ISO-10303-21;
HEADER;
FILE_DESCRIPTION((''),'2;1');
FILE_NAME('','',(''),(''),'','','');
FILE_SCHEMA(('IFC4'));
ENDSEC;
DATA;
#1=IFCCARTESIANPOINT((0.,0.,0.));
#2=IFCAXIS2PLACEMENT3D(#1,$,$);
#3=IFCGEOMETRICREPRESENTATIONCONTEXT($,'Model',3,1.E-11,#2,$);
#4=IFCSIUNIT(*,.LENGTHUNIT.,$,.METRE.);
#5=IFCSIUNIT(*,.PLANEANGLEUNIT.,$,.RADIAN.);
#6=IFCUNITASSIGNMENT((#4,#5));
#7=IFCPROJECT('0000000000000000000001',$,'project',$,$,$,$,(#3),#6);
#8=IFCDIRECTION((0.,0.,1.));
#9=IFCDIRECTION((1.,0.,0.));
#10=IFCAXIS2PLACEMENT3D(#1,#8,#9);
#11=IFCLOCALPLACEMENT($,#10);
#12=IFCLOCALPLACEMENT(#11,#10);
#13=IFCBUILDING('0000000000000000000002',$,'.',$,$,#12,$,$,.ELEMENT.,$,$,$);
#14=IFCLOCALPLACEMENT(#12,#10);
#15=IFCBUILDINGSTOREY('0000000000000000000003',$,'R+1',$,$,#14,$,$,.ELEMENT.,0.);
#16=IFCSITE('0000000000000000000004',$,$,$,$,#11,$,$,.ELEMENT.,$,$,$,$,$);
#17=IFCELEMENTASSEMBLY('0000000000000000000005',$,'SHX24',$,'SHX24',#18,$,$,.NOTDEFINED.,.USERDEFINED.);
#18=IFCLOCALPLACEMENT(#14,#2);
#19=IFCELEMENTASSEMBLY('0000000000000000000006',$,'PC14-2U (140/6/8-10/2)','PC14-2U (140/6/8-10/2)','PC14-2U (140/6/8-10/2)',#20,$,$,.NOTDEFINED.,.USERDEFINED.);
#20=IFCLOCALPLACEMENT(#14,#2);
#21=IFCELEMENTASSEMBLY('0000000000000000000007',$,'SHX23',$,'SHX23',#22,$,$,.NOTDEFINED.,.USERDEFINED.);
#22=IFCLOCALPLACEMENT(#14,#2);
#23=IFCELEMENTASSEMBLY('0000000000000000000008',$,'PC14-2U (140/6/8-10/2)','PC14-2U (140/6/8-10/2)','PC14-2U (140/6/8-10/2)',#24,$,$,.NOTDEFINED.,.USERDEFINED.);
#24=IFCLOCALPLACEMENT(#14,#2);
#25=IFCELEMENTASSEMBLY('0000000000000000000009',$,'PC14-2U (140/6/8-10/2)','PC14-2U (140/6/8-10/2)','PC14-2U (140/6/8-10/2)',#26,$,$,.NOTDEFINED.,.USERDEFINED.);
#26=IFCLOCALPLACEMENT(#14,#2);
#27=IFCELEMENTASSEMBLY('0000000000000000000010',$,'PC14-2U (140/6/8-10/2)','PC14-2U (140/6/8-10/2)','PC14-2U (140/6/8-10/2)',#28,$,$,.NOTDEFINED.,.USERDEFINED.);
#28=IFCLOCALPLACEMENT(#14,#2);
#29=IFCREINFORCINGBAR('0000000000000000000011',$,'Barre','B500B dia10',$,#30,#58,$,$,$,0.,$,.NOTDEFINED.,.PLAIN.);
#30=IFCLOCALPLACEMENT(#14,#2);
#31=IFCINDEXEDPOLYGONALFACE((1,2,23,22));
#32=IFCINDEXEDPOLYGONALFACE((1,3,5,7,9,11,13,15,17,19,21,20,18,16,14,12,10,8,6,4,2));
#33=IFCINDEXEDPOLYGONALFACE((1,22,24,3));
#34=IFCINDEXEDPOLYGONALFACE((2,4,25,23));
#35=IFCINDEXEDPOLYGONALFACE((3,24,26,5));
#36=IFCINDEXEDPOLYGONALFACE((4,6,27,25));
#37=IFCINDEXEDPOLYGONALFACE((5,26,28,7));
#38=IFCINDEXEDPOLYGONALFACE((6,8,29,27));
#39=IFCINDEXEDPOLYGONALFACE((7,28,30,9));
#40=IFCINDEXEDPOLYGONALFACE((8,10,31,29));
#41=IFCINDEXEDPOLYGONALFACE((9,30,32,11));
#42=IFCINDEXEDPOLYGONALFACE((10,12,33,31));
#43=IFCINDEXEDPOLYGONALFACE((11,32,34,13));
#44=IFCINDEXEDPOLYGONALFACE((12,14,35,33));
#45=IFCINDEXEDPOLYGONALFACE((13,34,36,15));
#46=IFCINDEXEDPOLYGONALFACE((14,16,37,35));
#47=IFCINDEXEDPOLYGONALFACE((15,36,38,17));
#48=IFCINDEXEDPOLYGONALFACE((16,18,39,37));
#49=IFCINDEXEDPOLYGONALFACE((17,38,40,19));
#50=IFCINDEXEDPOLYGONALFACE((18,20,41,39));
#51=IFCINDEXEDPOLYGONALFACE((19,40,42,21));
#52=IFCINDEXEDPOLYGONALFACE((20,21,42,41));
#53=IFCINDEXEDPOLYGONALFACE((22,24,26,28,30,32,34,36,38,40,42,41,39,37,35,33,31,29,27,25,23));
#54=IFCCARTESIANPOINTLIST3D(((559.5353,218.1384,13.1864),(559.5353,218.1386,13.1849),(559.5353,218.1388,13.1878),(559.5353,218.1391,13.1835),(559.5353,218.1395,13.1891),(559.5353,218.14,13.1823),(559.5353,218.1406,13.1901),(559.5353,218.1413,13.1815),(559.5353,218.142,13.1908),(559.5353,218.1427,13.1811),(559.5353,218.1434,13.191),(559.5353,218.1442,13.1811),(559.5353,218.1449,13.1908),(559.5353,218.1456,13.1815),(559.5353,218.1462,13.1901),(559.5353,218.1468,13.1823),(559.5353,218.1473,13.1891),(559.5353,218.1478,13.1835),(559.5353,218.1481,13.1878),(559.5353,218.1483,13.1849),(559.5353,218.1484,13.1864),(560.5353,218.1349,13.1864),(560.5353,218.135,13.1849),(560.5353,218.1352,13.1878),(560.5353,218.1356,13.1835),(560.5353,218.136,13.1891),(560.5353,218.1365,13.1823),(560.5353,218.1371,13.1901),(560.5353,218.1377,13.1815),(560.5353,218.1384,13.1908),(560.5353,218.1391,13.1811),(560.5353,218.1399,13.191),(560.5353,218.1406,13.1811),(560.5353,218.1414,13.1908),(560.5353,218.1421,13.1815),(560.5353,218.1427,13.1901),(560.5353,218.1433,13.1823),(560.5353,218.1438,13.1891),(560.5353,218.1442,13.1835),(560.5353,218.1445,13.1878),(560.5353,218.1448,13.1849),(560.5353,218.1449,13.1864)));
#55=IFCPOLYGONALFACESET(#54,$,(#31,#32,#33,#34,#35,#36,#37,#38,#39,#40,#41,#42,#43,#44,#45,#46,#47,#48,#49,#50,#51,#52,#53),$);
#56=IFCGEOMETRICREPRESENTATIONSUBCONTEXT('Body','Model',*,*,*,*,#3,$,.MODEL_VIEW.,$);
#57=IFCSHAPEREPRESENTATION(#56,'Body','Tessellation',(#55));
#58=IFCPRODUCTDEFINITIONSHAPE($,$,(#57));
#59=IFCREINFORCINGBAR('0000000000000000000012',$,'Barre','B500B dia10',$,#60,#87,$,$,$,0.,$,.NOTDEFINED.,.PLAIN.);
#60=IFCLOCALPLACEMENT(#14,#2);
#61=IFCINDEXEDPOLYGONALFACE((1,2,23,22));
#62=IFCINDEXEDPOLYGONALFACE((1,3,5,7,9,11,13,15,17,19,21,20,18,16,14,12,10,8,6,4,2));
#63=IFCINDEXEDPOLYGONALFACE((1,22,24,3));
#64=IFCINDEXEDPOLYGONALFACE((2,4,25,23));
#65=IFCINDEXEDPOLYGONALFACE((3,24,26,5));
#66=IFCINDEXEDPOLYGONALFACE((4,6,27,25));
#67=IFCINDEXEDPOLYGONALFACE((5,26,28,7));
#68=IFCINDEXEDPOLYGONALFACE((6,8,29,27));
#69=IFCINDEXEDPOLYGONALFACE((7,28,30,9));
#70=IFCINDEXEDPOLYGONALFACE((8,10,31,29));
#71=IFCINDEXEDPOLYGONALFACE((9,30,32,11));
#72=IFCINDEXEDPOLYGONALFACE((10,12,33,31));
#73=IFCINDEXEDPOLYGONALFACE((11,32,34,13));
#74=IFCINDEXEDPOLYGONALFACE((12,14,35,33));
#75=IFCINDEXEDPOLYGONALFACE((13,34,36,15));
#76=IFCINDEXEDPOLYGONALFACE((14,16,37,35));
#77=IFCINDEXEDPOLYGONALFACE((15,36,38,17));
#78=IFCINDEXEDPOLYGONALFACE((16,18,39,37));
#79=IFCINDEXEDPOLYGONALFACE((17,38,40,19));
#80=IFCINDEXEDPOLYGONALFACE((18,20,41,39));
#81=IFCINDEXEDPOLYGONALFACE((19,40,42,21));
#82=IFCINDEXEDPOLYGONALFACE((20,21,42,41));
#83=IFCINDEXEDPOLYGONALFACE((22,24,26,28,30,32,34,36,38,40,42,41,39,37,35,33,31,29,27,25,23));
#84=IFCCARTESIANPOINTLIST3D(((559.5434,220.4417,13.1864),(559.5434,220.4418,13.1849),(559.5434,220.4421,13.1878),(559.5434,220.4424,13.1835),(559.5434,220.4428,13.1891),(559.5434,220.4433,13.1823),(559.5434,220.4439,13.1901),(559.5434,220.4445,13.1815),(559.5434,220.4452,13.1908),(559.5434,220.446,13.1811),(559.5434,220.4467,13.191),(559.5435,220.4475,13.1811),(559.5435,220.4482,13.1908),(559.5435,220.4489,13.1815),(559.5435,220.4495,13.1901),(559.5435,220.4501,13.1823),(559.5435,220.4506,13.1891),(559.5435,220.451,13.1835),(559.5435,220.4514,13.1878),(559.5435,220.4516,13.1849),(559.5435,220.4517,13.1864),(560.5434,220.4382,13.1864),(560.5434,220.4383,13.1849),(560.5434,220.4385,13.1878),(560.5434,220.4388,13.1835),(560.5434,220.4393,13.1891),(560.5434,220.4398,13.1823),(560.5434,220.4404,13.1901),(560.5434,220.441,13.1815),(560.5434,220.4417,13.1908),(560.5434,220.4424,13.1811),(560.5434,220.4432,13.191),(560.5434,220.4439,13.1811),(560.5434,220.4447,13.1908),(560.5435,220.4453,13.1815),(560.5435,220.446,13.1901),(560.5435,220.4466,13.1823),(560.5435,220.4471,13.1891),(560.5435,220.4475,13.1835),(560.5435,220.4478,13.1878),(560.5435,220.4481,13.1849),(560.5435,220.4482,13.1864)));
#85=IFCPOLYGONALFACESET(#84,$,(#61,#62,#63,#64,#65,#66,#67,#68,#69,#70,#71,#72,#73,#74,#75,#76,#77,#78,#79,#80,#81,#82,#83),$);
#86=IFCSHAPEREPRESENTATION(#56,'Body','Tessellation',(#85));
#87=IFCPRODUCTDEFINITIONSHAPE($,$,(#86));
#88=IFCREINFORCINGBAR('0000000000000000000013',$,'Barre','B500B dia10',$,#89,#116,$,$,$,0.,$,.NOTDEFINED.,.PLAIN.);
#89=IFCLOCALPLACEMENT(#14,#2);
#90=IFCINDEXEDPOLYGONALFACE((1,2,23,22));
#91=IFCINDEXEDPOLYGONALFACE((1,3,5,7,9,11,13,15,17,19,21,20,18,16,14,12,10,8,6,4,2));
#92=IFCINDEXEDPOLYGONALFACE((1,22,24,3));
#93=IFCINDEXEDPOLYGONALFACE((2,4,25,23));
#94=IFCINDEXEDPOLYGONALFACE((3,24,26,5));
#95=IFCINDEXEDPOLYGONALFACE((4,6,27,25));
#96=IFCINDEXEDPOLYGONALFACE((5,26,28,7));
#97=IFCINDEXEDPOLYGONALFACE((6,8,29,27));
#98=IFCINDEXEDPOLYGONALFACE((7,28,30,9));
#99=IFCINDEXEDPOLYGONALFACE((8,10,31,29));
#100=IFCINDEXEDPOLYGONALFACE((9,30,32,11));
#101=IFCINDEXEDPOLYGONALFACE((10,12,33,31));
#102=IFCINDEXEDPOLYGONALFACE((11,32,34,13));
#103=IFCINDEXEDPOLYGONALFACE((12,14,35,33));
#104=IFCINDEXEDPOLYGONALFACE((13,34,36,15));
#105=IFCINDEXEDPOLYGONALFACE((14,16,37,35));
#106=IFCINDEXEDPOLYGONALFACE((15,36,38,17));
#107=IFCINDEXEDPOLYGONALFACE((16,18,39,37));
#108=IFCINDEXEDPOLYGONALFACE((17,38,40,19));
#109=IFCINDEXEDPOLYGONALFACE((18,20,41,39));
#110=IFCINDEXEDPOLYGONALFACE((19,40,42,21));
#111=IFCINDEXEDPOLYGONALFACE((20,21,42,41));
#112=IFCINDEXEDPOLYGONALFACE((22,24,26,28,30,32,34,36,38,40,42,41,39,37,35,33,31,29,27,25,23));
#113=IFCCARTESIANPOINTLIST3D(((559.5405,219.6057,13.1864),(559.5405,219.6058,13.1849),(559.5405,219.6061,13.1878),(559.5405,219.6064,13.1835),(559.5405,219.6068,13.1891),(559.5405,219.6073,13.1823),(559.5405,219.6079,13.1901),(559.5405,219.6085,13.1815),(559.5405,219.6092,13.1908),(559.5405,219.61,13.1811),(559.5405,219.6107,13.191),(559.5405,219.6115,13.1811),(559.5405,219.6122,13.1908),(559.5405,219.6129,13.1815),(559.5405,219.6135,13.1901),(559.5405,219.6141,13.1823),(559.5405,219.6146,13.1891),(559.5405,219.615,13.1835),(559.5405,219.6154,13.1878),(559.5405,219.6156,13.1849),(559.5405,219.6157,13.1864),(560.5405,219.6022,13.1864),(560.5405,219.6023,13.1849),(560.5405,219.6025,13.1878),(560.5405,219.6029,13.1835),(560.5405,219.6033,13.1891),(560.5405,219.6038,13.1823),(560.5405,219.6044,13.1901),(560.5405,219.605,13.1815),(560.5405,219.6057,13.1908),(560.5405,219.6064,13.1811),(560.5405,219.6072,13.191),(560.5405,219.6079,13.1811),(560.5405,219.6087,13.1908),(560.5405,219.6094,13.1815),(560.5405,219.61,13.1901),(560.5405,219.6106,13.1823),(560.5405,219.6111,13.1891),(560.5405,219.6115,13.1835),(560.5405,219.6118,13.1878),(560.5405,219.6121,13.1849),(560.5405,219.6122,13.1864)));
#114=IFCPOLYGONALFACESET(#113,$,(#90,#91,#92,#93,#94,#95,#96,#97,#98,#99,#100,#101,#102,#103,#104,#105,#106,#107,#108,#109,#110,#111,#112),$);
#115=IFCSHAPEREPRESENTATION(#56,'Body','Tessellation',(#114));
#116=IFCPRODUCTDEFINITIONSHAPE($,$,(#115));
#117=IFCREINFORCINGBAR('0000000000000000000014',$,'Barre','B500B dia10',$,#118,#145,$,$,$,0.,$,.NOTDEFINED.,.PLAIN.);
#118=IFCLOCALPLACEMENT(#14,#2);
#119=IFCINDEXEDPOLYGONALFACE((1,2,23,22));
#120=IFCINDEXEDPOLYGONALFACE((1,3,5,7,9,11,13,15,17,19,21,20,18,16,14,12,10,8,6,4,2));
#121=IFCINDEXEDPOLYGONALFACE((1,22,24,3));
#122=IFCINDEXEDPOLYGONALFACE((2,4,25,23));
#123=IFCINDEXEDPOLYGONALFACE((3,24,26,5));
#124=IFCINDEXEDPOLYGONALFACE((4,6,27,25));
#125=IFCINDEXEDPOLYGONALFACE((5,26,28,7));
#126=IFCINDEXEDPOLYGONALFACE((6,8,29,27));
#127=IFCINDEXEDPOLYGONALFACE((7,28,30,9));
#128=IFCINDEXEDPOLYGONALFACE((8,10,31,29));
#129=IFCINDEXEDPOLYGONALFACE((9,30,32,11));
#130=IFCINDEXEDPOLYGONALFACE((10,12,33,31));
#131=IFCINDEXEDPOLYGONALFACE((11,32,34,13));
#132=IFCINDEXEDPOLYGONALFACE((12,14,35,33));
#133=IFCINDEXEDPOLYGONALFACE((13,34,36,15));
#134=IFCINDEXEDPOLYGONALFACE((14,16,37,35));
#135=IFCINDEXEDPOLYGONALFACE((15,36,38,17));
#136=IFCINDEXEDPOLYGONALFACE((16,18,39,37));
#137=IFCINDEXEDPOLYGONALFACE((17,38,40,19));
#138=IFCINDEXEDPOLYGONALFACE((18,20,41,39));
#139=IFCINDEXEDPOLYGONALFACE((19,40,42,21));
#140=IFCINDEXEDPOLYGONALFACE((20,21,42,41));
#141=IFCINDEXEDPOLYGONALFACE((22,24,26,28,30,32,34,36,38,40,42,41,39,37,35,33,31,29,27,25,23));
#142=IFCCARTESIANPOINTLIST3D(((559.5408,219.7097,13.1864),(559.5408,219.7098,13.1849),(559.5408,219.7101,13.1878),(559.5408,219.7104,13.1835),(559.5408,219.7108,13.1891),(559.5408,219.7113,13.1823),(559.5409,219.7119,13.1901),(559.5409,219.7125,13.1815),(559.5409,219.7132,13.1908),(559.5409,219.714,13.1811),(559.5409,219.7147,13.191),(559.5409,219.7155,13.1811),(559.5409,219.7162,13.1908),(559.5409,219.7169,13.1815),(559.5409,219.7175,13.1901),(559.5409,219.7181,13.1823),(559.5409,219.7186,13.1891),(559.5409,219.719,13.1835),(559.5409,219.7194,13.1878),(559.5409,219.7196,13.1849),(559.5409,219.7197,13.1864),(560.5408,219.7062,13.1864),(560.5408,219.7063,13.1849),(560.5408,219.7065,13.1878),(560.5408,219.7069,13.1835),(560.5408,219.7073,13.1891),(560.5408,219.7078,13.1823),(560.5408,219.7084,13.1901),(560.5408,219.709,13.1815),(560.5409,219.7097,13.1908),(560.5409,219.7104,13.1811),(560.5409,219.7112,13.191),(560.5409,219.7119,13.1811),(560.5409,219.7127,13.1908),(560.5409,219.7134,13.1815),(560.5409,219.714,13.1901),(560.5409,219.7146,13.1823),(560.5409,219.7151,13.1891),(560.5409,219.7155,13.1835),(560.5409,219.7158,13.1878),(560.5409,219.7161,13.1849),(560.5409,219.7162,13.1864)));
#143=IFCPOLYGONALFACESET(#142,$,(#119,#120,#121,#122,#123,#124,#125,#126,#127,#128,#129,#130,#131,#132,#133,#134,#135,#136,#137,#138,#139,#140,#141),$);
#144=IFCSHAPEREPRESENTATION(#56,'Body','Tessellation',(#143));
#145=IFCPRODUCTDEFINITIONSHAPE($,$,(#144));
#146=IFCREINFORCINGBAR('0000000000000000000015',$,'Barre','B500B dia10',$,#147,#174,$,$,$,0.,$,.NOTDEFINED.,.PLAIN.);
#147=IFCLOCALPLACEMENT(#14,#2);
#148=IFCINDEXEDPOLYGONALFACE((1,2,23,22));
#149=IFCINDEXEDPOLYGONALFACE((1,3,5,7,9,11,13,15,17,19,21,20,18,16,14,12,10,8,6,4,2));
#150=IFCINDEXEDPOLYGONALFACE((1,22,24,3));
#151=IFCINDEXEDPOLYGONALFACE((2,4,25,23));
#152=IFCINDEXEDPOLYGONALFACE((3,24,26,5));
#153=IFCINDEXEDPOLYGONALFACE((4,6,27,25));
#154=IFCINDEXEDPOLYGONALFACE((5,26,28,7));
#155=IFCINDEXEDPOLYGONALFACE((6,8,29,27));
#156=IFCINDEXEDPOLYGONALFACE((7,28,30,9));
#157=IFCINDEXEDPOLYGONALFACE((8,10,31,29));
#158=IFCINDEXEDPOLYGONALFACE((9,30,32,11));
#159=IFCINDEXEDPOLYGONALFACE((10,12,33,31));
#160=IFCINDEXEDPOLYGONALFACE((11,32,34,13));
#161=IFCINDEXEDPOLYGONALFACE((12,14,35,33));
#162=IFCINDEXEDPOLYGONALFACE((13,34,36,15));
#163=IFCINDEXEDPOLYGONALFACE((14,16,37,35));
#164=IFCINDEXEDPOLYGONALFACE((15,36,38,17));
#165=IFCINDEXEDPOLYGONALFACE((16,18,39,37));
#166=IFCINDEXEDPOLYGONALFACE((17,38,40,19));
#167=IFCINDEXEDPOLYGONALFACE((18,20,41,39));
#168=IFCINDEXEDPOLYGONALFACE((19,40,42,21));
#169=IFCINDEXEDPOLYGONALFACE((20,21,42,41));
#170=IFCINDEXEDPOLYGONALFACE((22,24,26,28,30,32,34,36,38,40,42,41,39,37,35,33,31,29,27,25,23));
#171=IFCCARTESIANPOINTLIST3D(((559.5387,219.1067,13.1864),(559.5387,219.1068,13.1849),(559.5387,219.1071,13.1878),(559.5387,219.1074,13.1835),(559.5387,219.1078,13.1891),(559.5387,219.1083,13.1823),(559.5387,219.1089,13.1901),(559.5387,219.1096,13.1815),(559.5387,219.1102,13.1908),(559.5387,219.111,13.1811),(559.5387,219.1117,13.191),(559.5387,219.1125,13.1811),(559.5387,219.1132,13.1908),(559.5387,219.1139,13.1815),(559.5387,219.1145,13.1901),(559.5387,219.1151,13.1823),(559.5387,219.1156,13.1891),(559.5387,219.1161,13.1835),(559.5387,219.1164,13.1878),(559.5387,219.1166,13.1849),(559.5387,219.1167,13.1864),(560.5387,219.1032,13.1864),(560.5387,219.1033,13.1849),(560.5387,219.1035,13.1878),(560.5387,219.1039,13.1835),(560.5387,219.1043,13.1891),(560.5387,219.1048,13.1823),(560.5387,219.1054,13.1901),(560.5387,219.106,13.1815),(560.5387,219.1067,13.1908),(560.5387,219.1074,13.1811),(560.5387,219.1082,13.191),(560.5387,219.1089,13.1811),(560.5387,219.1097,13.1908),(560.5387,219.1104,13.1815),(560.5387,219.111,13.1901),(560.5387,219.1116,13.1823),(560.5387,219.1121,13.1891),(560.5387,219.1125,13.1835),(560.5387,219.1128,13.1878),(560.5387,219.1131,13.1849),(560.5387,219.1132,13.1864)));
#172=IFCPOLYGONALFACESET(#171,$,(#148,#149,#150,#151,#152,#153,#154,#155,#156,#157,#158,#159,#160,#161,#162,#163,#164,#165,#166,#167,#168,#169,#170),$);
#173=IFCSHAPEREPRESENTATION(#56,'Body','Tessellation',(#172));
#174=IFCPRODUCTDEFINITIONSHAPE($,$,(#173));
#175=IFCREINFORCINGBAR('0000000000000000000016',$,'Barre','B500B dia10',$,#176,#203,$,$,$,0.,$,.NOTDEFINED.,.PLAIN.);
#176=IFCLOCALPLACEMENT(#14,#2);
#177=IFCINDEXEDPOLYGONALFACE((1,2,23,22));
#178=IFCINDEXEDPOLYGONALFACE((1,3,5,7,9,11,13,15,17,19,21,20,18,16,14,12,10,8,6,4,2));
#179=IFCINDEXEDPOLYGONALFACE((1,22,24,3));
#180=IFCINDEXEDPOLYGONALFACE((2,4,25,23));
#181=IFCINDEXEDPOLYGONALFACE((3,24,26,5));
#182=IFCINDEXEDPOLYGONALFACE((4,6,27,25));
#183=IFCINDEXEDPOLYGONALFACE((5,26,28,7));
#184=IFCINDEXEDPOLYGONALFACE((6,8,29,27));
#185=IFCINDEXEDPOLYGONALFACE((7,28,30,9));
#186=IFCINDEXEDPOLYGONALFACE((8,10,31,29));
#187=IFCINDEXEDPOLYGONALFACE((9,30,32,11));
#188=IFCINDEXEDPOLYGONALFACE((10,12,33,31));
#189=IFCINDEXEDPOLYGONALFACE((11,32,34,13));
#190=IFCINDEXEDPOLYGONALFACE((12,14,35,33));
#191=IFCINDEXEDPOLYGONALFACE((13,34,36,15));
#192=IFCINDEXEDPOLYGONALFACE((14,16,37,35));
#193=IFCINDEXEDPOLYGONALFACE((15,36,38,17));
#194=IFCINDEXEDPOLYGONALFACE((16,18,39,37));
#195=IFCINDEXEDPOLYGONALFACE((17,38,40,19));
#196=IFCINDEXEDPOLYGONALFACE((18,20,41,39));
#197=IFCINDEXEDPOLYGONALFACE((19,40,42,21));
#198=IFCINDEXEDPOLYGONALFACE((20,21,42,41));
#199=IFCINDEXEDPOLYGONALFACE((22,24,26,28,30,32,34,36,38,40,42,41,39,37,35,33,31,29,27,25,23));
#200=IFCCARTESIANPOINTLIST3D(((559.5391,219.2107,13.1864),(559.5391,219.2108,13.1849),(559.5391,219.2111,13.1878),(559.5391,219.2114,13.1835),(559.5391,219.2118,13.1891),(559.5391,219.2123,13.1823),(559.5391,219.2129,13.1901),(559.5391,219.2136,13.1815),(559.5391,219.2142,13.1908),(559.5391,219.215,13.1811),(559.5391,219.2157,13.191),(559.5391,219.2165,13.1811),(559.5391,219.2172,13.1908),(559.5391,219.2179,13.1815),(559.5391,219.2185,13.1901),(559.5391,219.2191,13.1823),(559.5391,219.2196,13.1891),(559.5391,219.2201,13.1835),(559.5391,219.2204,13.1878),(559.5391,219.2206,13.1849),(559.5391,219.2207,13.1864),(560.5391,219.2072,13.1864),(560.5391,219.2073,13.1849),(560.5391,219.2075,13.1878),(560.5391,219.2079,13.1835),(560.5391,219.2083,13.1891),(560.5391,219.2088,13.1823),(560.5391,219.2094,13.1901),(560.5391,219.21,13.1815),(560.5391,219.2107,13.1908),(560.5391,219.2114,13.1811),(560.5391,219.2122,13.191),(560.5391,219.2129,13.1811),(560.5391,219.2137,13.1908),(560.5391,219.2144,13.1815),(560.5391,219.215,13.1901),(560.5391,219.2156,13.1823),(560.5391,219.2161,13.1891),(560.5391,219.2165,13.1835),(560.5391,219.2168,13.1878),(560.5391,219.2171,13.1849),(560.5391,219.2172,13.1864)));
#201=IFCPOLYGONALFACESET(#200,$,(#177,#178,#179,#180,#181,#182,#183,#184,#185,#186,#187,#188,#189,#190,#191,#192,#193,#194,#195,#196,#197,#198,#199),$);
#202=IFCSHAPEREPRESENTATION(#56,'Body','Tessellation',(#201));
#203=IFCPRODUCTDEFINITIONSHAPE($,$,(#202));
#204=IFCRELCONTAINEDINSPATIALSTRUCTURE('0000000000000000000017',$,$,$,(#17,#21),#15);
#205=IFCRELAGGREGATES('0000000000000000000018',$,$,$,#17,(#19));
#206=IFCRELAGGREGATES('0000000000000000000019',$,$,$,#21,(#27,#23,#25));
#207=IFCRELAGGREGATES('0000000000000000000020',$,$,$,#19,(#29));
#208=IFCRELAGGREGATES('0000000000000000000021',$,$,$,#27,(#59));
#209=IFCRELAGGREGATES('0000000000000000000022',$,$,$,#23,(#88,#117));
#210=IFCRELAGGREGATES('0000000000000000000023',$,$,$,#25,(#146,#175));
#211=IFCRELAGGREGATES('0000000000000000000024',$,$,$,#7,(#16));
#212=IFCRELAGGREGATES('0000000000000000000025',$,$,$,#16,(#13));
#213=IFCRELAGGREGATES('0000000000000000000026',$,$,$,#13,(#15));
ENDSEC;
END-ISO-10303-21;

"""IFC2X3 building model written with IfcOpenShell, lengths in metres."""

from ifc_helpers import new_model, entity, si_unit, frame, origin, origin_with_axes, place, context, subcontext, project, spatial, source, transform, mapped, element, aggregate, save


model = new_model("IFC2X3")

# Units and contexts
model_context = context("Model", 3, precision=1e-11, world=origin())
body_context = subcontext(model_context, "Body", "Model", "MODEL_VIEW")
ifc_project = project(units=[si_unit("LENGTHUNIT", "METRE"), si_unit("PLANEANGLEUNIT", "RADIAN")], contexts=[model_context])

# Site, building, storey
site_placement = place(None, origin_with_axes())
site = spatial("IfcSite", under=ifc_project, at=site_placement, CompositionType="ELEMENT")
building_placement = place(site_placement, origin_with_axes())
building = spatial("IfcBuilding", under=site, at=building_placement, Name=".", CompositionType="ELEMENT")
storey_placement = place(building_placement, origin_with_axes())
storey = spatial("IfcBuildingStorey", under=building, at=storey_placement, Name="R+1", CompositionType="ELEMENT", Elevation=0.0)

# Element assemblies
assembly_1_placement = place(storey_placement, origin_with_axes())
assembly_1 = element("IfcElementAssembly", 1, at=assembly_1_placement, inside=storey, Name="SHX24", ObjectType="SHX24", AssemblyPlace="NOTDEFINED", PredefinedType="USERDEFINED")
assembly_2_placement = place(assembly_1_placement, origin_with_axes())
assembly_2 = element("IfcElementAssembly", 2, at=assembly_2_placement, Name="PC14-2U (140/6/8-10/2)", Description="PC14-2U (140/6/8-10/2)", ObjectType="PC14-2U (140/6/8-10/2)", AssemblyPlace="NOTDEFINED", PredefinedType="USERDEFINED")
aggregate(assembly_1, [assembly_2])
assembly_3_placement = place(storey_placement, origin_with_axes())
assembly_3 = element("IfcElementAssembly", 3, at=assembly_3_placement, inside=storey, Name="SHX23", ObjectType="SHX23", AssemblyPlace="NOTDEFINED", PredefinedType="USERDEFINED")
assembly_4_placement = place(assembly_3_placement, origin_with_axes())
assembly_4 = element("IfcElementAssembly", 4, at=assembly_4_placement, Name="PC14-2U (140/6/8-10/2)", Description="PC14-2U (140/6/8-10/2)", ObjectType="PC14-2U (140/6/8-10/2)", AssemblyPlace="NOTDEFINED", PredefinedType="USERDEFINED")
assembly_5_placement = place(assembly_3_placement, origin_with_axes())
assembly_5 = element("IfcElementAssembly", 5, at=assembly_5_placement, Name="PC14-2U (140/6/8-10/2)", Description="PC14-2U (140/6/8-10/2)", ObjectType="PC14-2U (140/6/8-10/2)", AssemblyPlace="NOTDEFINED", PredefinedType="USERDEFINED")

# Element assembly
assembly_6_placement = place(assembly_3_placement, origin_with_axes())
assembly_6 = element("IfcElementAssembly", 6, at=assembly_6_placement, Name="PC14-2U (140/6/8-10/2)", Description="PC14-2U (140/6/8-10/2)", ObjectType="PC14-2U (140/6/8-10/2)", AssemblyPlace="NOTDEFINED", PredefinedType="USERDEFINED")
aggregate(assembly_3, [assembly_6, assembly_4, assembly_5])

# Reinforcing bars
shared_shape_1 = source(origin_with_axes(), body_context, "Body", "AdvancedSweptSolid", [
    entity("IfcSweptDiskSolid", entity("IfcPolyline", [entity("IfcCartesianPoint", [0.0, 0.0, 0.011]), entity("IfcCartesianPoint", [0.0, 1.0, 0.011])]), 0.005, None, 0.0, 1.0),
])
reinforcing_bar_1_placement = place(assembly_2_placement, frame((560.5353, 218.1399, 13.175), z_axis=(0.0, 0.0, 1.0), x_axis=(0.003536, 0.999994, 0.0)))
reinforcing_bar_1 = element("IfcReinforcingBar", 7, at=reinforcing_bar_1_placement, Name="Barre", Description="B500B dia10", BarRole="NOTDEFINED", BarSurface="PLAIN", CrossSectionArea=0.0, context=body_context, shape_type="MappedRepresentation", body=[
    mapped(shared_shape_1, transform((0.0, 0.0, 0.0), scale=1.0)),
])
aggregate(assembly_2, [reinforcing_bar_1])
reinforcing_bar_2_placement = place(assembly_6_placement, frame((560.5434, 220.4432, 13.175), z_axis=(0.0, 0.0, 1.0), x_axis=(0.003536, 0.999994, 0.0)))
reinforcing_bar_2 = element("IfcReinforcingBar", 8, at=reinforcing_bar_2_placement, Name="Barre", Description="B500B dia10", BarRole="NOTDEFINED", BarSurface="PLAIN", CrossSectionArea=0.0, context=body_context, shape_type="MappedRepresentation", body=[
    mapped(shared_shape_1, transform((0.0, 0.0, 0.0), scale=1.0)),
])
aggregate(assembly_6, [reinforcing_bar_2])
reinforcing_bar_3_placement = place(assembly_4_placement, frame((560.5405, 219.6072, 13.175), z_axis=(0.0, 0.0, 1.0), x_axis=(0.003536, 0.999994, 0.0)))
reinforcing_bar_3 = element("IfcReinforcingBar", 9, at=reinforcing_bar_3_placement, Name="Barre", Description="B500B dia10", BarRole="NOTDEFINED", BarSurface="PLAIN", CrossSectionArea=0.0, context=body_context, shape_type="MappedRepresentation", body=[
    mapped(shared_shape_1, transform((0.0, 0.0, 0.0), scale=1.0)),
])
reinforcing_bar_4_placement = place(assembly_4_placement, frame((560.5409, 219.7112, 13.175), z_axis=(0.0, 0.0, 1.0), x_axis=(0.003536, 0.999994, 0.0)))
reinforcing_bar_4 = element("IfcReinforcingBar", 10, at=reinforcing_bar_4_placement, Name="Barre", Description="B500B dia10", BarRole="NOTDEFINED", BarSurface="PLAIN", CrossSectionArea=0.0, context=body_context, shape_type="MappedRepresentation", body=[
    mapped(shared_shape_1, transform((0.0, 0.0, 0.0), scale=1.0)),
])
aggregate(assembly_4, [reinforcing_bar_3, reinforcing_bar_4])
reinforcing_bar_5_placement = place(assembly_5_placement, frame((560.5387, 219.1082, 13.175), z_axis=(0.0, 0.0, 1.0), x_axis=(0.003536, 0.999994, 0.0)))
reinforcing_bar_5 = element("IfcReinforcingBar", 11, at=reinforcing_bar_5_placement, Name="Barre", Description="B500B dia10", BarRole="NOTDEFINED", BarSurface="PLAIN", CrossSectionArea=0.0, context=body_context, shape_type="MappedRepresentation", body=[
    mapped(shared_shape_1, transform((0.0, 0.0, 0.0), scale=1.0)),
])
reinforcing_bar_6_placement = place(assembly_5_placement, frame((560.5391, 219.2122, 13.175), z_axis=(0.0, 0.0, 1.0), x_axis=(0.003536, 0.999994, 0.0)))
reinforcing_bar_6 = element("IfcReinforcingBar", 12, at=reinforcing_bar_6_placement, Name="Barre", Description="B500B dia10", BarRole="NOTDEFINED", BarSurface="PLAIN", CrossSectionArea=0.0, context=body_context, shape_type="MappedRepresentation", body=[
    mapped(shared_shape_1, transform((0.0, 0.0, 0.0), scale=1.0)),
])
aggregate(assembly_5, [reinforcing_bar_5, reinforcing_bar_6])

save(model, "model.ifc")
